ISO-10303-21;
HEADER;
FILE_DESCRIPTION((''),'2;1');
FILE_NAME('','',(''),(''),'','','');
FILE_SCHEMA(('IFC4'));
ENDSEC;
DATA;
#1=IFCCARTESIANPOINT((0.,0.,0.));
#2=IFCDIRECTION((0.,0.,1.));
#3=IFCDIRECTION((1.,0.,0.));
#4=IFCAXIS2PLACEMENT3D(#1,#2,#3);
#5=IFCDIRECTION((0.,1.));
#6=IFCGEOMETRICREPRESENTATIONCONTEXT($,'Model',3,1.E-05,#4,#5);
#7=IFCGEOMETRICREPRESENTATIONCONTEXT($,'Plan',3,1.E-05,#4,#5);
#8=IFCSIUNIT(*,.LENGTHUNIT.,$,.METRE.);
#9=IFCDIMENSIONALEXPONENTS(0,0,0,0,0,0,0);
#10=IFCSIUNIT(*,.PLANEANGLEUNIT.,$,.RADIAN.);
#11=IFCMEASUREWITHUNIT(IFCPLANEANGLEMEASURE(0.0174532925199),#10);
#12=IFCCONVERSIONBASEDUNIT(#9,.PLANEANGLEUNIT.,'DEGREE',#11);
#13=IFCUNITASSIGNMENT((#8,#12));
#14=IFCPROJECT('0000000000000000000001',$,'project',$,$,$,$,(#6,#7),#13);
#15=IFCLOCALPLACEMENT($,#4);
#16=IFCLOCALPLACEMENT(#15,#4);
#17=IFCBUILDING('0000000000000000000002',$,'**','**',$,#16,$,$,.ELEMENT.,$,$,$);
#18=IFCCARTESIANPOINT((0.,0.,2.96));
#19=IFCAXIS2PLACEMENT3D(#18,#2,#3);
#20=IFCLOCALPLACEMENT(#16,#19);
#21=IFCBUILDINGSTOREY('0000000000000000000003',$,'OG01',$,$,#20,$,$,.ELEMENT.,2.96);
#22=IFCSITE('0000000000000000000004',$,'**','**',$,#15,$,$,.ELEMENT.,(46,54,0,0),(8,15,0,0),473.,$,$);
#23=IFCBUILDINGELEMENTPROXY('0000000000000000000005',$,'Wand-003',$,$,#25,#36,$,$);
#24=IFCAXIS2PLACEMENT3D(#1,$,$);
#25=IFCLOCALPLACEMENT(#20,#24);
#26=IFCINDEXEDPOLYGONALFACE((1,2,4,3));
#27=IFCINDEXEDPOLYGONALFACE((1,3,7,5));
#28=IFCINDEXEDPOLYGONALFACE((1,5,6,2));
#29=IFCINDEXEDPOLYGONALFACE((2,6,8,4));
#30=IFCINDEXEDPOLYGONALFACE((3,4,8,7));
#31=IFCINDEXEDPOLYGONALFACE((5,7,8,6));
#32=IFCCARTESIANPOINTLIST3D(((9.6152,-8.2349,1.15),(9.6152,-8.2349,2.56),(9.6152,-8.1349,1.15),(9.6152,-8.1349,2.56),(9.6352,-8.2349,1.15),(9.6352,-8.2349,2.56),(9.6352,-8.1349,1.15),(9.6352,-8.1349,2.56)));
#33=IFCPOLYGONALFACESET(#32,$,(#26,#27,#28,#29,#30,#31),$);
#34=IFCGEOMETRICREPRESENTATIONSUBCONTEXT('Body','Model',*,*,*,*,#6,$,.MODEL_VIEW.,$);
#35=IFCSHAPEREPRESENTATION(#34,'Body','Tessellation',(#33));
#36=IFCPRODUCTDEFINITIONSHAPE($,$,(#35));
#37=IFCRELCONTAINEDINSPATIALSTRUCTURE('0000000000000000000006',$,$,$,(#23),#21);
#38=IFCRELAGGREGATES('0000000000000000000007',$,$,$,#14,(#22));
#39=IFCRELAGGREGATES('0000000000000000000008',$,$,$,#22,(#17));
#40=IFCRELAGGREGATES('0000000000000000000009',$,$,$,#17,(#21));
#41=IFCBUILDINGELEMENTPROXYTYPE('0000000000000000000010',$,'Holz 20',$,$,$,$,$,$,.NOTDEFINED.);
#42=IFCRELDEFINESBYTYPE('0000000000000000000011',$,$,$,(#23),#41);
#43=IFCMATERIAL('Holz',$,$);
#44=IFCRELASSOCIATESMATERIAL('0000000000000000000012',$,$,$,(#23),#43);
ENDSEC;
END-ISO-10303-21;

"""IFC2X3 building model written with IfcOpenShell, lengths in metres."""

from ifc_helpers import new_model, entity, si_unit, converted_unit, direction, frame, origin_with_axes, place, context, subcontext, project, spatial, polyline, outline, extrude, material, type_object, element, save


model = new_model("IFC2X3")

# Units and contexts
model_context = context("Model", 3, precision=1e-05, world=origin_with_axes(), true_north=direction((0.0, 1.0)))
plan_context = context("Plan", 3, precision=1e-05, world=origin_with_axes(), true_north=direction((0.0, 1.0)))
body_context = subcontext(model_context, "Body", "Model", "MODEL_VIEW")
ifc_project = project(units=[si_unit("LENGTHUNIT", "METRE"), converted_unit("PLANEANGLEUNIT", "DEGREE", entity("IfcPlaneAngleMeasure", 0.0174532925199), si_unit("PLANEANGLEUNIT", "RADIAN"), dimensions=[0, 0, 0, 0, 0, 0, 0])], contexts=[model_context, plan_context])

# Site, building, storey
site_placement = place(None, origin_with_axes())
site = spatial("IfcSite", under=ifc_project, at=site_placement, Name="**", Description="**", CompositionType="ELEMENT", RefLatitude=(46, 54, 0, 0), RefLongitude=(8, 15, 0, 0), RefElevation=473.0)
building_placement = place(site_placement, origin_with_axes())
building = spatial("IfcBuilding", under=site, at=building_placement, Name="**", Description="**", CompositionType="ELEMENT")
storey_placement = place(building_placement, frame((0.0, 0.0, 2.96), z_axis=(0.0, 0.0, 1.0), x_axis=(1.0, 0.0, 0.0)))
storey = spatial("IfcBuildingStorey", under=building, at=storey_placement, Name="OG01", CompositionType="ELEMENT", Elevation=2.96)

# Shared definitions
ifc_material_1 = material(Name="Holz")

# Building element proxy
building_element_proxy_type_1 = type_object("IfcBuildingElementProxyType", Name="Holz 20", PredefinedType="NOTDEFINED")
proxy_1_placement = place(storey_placement, frame((9.6352, -8.1349, 1.15), z_axis=(0.0, 0.0, 1.0), x_axis=(0.0, -1.0, 0.0)))
element("IfcBuildingElementProxy", 1, at=proxy_1_placement, inside=storey, type_object=building_element_proxy_type_1, material=ifc_material_1, Name="Wand-003", context=body_context, shape_type="SweptSolid", body=[
    extrude(outline(polyline([(0.0, -0.02), (0.1, -0.02), (0.1, 0.0), (0.0, 0.0), (0.0, -0.02)])), origin_with_axes(), (0.0, 0.0, 1.0), 1.41),
])

save(model, "model.ifc")
